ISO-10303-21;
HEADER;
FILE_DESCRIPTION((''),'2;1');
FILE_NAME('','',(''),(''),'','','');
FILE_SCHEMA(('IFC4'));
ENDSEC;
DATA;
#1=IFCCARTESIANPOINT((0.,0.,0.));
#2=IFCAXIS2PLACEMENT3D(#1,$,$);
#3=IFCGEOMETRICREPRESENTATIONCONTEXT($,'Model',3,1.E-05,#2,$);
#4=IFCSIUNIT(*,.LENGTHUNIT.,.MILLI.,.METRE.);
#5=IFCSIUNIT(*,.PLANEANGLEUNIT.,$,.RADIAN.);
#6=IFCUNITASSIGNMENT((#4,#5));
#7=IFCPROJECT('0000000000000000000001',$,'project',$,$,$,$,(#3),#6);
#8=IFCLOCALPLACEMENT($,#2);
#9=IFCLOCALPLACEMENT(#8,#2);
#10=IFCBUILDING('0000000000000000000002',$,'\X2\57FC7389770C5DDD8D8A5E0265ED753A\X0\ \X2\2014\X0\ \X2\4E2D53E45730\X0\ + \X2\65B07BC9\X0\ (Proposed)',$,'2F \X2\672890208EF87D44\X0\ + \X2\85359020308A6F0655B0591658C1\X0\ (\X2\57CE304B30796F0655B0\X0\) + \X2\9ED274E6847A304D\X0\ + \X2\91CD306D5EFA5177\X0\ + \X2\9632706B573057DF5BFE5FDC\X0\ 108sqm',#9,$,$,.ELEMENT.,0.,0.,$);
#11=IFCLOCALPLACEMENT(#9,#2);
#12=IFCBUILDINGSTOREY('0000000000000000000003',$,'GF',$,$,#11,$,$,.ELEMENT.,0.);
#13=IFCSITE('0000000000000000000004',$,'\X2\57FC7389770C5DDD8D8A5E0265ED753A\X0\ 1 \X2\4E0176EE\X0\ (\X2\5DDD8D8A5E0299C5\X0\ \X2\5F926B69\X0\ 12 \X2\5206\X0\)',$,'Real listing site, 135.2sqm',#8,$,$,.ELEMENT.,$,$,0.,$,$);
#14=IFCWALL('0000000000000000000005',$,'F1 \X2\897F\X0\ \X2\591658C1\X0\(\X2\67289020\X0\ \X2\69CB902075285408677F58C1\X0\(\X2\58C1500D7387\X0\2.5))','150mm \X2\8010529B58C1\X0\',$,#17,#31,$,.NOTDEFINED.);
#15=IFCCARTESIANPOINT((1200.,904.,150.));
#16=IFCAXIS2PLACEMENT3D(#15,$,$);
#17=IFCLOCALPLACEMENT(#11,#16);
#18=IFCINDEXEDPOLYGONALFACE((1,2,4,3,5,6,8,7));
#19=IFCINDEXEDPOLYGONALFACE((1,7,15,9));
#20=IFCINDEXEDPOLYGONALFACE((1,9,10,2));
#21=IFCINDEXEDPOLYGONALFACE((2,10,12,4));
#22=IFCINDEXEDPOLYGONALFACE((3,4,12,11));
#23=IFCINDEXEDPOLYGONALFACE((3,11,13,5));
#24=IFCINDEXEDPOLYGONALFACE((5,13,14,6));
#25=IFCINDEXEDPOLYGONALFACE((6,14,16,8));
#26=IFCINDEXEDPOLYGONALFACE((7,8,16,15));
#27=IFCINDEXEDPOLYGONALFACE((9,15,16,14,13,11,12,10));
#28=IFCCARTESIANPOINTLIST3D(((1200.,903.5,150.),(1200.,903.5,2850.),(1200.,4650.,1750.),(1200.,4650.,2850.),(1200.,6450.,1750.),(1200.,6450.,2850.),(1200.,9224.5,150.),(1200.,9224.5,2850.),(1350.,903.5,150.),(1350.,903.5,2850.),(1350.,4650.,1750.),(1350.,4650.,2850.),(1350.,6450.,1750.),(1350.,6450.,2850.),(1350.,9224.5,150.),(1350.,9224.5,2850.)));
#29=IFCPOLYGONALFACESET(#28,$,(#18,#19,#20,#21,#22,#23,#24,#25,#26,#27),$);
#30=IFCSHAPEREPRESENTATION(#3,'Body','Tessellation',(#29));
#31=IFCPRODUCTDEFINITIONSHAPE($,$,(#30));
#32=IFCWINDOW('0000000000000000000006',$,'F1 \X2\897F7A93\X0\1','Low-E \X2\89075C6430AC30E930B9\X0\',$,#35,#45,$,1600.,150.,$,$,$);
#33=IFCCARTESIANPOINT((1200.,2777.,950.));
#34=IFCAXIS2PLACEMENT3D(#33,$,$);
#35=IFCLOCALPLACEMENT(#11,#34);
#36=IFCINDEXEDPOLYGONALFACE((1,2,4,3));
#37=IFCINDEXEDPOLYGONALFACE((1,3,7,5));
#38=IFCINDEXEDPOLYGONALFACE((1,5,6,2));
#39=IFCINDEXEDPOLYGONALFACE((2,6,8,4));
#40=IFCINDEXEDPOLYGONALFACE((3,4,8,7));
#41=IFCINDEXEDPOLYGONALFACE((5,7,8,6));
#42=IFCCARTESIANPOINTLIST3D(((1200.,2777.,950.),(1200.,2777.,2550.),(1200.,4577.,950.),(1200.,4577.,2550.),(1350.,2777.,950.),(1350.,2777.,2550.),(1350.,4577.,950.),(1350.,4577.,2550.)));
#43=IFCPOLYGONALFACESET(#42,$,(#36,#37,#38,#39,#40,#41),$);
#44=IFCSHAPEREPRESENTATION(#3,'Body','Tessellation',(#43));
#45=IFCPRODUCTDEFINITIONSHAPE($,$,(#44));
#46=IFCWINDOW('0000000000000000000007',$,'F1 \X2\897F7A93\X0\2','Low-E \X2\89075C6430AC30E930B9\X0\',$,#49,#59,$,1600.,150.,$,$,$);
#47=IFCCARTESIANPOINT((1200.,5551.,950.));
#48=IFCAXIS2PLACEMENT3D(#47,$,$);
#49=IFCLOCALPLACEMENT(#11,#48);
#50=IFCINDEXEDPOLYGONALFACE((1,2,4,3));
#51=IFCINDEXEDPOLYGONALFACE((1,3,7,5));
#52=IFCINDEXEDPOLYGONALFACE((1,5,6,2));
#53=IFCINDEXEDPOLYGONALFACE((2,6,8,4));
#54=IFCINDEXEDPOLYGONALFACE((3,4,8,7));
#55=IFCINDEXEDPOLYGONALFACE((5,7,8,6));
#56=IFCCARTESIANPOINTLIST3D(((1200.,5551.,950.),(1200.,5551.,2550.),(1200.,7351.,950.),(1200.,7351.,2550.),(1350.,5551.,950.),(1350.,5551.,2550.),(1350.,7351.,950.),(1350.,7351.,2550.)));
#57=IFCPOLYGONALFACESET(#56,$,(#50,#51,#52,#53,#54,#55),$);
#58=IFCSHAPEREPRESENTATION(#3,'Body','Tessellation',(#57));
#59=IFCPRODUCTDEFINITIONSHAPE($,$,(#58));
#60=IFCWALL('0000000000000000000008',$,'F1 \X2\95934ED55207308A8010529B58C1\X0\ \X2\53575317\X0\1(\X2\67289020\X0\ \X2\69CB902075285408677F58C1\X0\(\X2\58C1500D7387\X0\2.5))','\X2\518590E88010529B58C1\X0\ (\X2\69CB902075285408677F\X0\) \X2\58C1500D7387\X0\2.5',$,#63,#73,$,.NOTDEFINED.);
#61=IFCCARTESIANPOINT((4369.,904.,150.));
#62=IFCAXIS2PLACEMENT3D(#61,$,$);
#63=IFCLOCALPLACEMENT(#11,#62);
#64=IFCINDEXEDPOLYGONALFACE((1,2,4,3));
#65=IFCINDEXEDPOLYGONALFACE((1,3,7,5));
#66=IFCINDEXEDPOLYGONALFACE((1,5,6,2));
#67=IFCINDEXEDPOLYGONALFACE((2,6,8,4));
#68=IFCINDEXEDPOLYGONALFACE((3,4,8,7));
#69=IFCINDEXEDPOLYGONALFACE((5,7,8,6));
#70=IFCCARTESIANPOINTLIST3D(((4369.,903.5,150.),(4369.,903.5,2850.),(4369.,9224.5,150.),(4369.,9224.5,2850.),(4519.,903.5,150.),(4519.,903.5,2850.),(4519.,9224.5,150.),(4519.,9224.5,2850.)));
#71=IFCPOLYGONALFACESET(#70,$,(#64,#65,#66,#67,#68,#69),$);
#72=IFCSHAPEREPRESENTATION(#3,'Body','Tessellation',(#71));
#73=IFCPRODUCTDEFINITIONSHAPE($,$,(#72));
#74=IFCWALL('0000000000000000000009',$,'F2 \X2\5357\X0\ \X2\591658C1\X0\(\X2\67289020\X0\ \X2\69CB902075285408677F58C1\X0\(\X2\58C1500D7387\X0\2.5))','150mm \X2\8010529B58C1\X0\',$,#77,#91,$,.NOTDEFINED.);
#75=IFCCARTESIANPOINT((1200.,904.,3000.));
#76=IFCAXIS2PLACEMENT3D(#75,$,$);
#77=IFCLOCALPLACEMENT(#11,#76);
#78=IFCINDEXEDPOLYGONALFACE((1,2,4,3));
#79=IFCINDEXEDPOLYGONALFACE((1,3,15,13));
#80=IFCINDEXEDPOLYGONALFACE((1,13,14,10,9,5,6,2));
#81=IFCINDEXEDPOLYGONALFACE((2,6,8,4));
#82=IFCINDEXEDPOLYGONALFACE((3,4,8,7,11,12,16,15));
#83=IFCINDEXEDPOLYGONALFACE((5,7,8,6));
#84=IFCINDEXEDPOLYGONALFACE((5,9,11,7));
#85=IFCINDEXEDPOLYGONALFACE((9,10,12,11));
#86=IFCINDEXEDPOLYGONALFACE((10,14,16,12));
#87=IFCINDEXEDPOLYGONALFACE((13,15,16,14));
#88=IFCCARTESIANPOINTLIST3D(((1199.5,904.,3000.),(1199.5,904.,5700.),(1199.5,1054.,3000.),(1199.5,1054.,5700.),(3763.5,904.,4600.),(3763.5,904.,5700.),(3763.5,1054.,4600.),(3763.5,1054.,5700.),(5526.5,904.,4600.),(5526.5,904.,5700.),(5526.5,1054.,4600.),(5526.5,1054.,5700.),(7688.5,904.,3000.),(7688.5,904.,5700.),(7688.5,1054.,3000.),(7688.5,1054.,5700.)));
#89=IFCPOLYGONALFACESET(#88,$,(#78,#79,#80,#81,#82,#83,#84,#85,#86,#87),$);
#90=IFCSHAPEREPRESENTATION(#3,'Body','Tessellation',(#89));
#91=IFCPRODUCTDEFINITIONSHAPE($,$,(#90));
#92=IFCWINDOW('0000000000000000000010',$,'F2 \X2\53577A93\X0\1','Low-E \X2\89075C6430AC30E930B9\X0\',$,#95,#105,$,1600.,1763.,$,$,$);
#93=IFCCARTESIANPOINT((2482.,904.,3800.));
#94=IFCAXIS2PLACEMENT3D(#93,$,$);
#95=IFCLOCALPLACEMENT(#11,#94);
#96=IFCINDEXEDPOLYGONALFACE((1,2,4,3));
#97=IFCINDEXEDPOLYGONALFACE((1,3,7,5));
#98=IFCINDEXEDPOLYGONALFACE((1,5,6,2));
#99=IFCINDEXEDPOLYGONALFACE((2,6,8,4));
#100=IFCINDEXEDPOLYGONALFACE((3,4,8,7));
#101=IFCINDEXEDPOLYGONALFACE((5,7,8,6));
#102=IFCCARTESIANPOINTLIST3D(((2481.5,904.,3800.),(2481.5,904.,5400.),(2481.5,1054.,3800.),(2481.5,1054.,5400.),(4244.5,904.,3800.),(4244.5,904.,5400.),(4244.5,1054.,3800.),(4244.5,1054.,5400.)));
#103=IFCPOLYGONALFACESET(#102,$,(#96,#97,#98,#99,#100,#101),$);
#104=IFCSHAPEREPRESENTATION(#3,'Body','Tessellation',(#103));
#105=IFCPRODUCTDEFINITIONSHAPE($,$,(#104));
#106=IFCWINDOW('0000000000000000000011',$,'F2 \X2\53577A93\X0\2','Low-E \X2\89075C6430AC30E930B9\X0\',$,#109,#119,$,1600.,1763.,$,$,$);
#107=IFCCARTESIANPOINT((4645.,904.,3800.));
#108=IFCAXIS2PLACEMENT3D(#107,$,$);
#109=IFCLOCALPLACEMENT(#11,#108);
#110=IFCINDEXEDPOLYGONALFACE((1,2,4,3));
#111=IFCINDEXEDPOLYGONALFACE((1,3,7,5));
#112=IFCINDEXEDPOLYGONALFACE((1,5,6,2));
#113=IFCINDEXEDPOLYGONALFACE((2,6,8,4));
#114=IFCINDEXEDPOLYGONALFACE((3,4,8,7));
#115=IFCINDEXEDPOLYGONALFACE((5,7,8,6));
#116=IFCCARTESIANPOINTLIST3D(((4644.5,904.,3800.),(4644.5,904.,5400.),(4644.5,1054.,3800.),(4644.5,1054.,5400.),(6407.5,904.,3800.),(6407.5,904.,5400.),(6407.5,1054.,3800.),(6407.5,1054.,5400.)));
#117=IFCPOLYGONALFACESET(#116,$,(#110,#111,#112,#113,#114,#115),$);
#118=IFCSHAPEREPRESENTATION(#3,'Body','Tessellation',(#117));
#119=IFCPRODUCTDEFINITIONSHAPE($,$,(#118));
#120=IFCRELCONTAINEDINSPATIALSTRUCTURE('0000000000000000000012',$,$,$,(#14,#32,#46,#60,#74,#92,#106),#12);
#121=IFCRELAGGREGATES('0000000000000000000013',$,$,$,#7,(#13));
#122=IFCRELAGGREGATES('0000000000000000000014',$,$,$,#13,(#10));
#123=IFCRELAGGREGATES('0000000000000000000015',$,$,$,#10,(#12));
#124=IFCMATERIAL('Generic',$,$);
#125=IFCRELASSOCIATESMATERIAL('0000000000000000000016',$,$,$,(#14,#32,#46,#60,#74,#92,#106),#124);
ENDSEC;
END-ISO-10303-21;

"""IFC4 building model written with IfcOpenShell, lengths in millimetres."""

from ifc_helpers import new_model, si_unit, frame, frame_2d, origin, place, context, project, spatial, rectangle, extrude, material, element, fill, save


model = new_model("IFC4")

# Units and contexts
model_context = context("Model", 3, precision=1e-05, world=origin())
ifc_project = project(units=[si_unit("LENGTHUNIT", "METRE", prefix="MILLI"), si_unit("PLANEANGLEUNIT", "RADIAN")], contexts=[model_context])

# Site, building, storey
site_placement = place(None, origin())
site = spatial("IfcSite", under=ifc_project, at=site_placement, Name="埼玉県川越市旭町 1 丁目 (川越市駅 徒歩 12 分)", ObjectType="Real listing site, 135.2sqm", CompositionType="ELEMENT", RefElevation=0.0)
building_placement = place(site_placement, origin())
building = spatial("IfcBuilding", under=site, at=building_placement, Name="埼玉県川越市旭町 — 中古地 + 新築 (Proposed)", ObjectType="2F 木造軸組 + 蔵造り漆喰外壁 (城かべ漆喰) + 黒瓦葺き + 重ね建具 + 防火地域対応 108sqm", CompositionType="ELEMENT", ElevationOfRefHeight=0.0, ElevationOfTerrain=0.0)
storey_placement = place(building_placement, origin())
storey = spatial("IfcBuildingStorey", under=building, at=storey_placement, Name="GF", CompositionType="ELEMENT", Elevation=0.0)

# Shared definitions
ifc_material_1 = material(Name="Generic")

# Wall, openings, windows
wall_1_placement = place(storey_placement, frame((1200.0, 904.0, 150.0)))
wall_1 = element("IfcWall", 1, at=wall_1_placement, inside=storey, material=ifc_material_1, Name="F1 西 外壁(木造 構造用合板壁(壁倍率2.5))", Description="150mm 耐力壁", PredefinedType="NOTDEFINED", context=model_context, shape_type="SweptSolid", body=[
    extrude(rectangle(XDim=150.0, YDim=8321.0, at=frame_2d((75.0, 4160.0))), frame((1200.0, 904.0, 150.0)), (0.0, 0.0, 1.0), 2700.0),
])
opening_1_placement = place(storey_placement, frame((1200.0, 2777.0, 950.0)))
opening_1 = element("IfcOpeningElement", 2, at=opening_1_placement, cuts=wall_1, PredefinedType="NOTDEFINED", context=model_context, shape_type="SweptSolid", body=[
    extrude(rectangle(XDim=150.0, YDim=1800.0, at=frame_2d((75.0, 900.0))), frame((1200.0, 2777.0, 950.0)), (0.0, 0.0, 1.0), 1600.0),
])
opening_2_placement = place(storey_placement, frame((1200.0, 5551.0, 950.0)))
opening_2 = element("IfcOpeningElement", 3, at=opening_2_placement, cuts=wall_1, PredefinedType="NOTDEFINED", context=model_context, shape_type="SweptSolid", body=[
    extrude(rectangle(XDim=150.0, YDim=1800.0, at=frame_2d((75.0, 900.0))), frame((1200.0, 5551.0, 950.0)), (0.0, 0.0, 1.0), 1600.0),
])
window_1_placement = place(storey_placement, frame((1200.0, 2777.0, 950.0)))
window_1 = element("IfcWindow", 4, at=window_1_placement, inside=storey, material=ifc_material_1, Name="F1 西窓1", Description="Low-E 複層ガラス", OverallHeight=1600.0, OverallWidth=150.0, context=model_context, shape_type="SweptSolid", body=[
    extrude(rectangle(XDim=150.0, YDim=1800.0, at=frame_2d((75.0, 900.0))), frame((1200.0, 2777.0, 950.0)), (0.0, 0.0, 1.0), 1600.0),
])
fill(opening_1, window_1)
window_2_placement = place(storey_placement, frame((1200.0, 5551.0, 950.0)))
window_2 = element("IfcWindow", 5, at=window_2_placement, inside=storey, material=ifc_material_1, Name="F1 西窓2", Description="Low-E 複層ガラス", OverallHeight=1600.0, OverallWidth=150.0, context=model_context, shape_type="SweptSolid", body=[
    extrude(rectangle(XDim=150.0, YDim=1800.0, at=frame_2d((75.0, 900.0))), frame((1200.0, 5551.0, 950.0)), (0.0, 0.0, 1.0), 1600.0),
])
fill(opening_2, window_2)

# Wall
wall_2_placement = place(storey_placement, frame((4369.0, 904.0, 150.0)))
element("IfcWall", 6, at=wall_2_placement, inside=storey, material=ifc_material_1, Name="F1 間仕切り耐力壁 南北1(木造 構造用合板壁(壁倍率2.5))", Description="内部耐力壁 (構造用合板) 壁倍率2.5", PredefinedType="NOTDEFINED", context=model_context, shape_type="SweptSolid", body=[
    extrude(rectangle(XDim=150.0, YDim=8321.0, at=frame_2d((75.0, 4160.0))), frame((4369.0, 904.0, 150.0)), (0.0, 0.0, 1.0), 2700.0),
])

# Wall, openings, windows
wall_3_placement = place(storey_placement, frame((1200.0, 904.0, 3000.0)))
wall_3 = element("IfcWall", 7, at=wall_3_placement, inside=storey, material=ifc_material_1, Name="F2 南 外壁(木造 構造用合板壁(壁倍率2.5))", Description="150mm 耐力壁", PredefinedType="NOTDEFINED", context=model_context, shape_type="SweptSolid", body=[
    extrude(rectangle(XDim=6489.0, YDim=150.0, at=frame_2d((3244.0, 75.0))), frame((1200.0, 904.0, 3000.0)), (0.0, 0.0, 1.0), 2700.0),
])
opening_3_placement = place(storey_placement, frame((2482.0, 904.0, 3800.0)))
opening_3 = element("IfcOpeningElement", 8, at=opening_3_placement, cuts=wall_3, PredefinedType="NOTDEFINED", context=model_context, shape_type="SweptSolid", body=[
    extrude(rectangle(XDim=1763.0, YDim=150.0, at=frame_2d((881.0, 75.0))), frame((2482.0, 904.0, 3800.0)), (0.0, 0.0, 1.0), 1600.0),
])
opening_4_placement = place(storey_placement, frame((4645.0, 904.0, 3800.0)))
opening_4 = element("IfcOpeningElement", 9, at=opening_4_placement, cuts=wall_3, PredefinedType="NOTDEFINED", context=model_context, shape_type="SweptSolid", body=[
    extrude(rectangle(XDim=1763.0, YDim=150.0, at=frame_2d((881.0, 75.0))), frame((4645.0, 904.0, 3800.0)), (0.0, 0.0, 1.0), 1600.0),
])
window_3_placement = place(storey_placement, frame((2482.0, 904.0, 3800.0)))
window_3 = element("IfcWindow", 10, at=window_3_placement, inside=storey, material=ifc_material_1, Name="F2 南窓1", Description="Low-E 複層ガラス", OverallHeight=1600.0, OverallWidth=1763.0, context=model_context, shape_type="SweptSolid", body=[
    extrude(rectangle(XDim=1763.0, YDim=150.0, at=frame_2d((881.0, 75.0))), frame((2482.0, 904.0, 3800.0)), (0.0, 0.0, 1.0), 1600.0),
])
fill(opening_3, window_3)
window_4_placement = place(storey_placement, frame((4645.0, 904.0, 3800.0)))
window_4 = element("IfcWindow", 11, at=window_4_placement, inside=storey, material=ifc_material_1, Name="F2 南窓2", Description="Low-E 複層ガラス", OverallHeight=1600.0, OverallWidth=1763.0, context=model_context, shape_type="SweptSolid", body=[
    extrude(rectangle(XDim=1763.0, YDim=150.0, at=frame_2d((881.0, 75.0))), frame((4645.0, 904.0, 3800.0)), (0.0, 0.0, 1.0), 1600.0),
])
fill(opening_4, window_4)

save(model, "model.ifc")
